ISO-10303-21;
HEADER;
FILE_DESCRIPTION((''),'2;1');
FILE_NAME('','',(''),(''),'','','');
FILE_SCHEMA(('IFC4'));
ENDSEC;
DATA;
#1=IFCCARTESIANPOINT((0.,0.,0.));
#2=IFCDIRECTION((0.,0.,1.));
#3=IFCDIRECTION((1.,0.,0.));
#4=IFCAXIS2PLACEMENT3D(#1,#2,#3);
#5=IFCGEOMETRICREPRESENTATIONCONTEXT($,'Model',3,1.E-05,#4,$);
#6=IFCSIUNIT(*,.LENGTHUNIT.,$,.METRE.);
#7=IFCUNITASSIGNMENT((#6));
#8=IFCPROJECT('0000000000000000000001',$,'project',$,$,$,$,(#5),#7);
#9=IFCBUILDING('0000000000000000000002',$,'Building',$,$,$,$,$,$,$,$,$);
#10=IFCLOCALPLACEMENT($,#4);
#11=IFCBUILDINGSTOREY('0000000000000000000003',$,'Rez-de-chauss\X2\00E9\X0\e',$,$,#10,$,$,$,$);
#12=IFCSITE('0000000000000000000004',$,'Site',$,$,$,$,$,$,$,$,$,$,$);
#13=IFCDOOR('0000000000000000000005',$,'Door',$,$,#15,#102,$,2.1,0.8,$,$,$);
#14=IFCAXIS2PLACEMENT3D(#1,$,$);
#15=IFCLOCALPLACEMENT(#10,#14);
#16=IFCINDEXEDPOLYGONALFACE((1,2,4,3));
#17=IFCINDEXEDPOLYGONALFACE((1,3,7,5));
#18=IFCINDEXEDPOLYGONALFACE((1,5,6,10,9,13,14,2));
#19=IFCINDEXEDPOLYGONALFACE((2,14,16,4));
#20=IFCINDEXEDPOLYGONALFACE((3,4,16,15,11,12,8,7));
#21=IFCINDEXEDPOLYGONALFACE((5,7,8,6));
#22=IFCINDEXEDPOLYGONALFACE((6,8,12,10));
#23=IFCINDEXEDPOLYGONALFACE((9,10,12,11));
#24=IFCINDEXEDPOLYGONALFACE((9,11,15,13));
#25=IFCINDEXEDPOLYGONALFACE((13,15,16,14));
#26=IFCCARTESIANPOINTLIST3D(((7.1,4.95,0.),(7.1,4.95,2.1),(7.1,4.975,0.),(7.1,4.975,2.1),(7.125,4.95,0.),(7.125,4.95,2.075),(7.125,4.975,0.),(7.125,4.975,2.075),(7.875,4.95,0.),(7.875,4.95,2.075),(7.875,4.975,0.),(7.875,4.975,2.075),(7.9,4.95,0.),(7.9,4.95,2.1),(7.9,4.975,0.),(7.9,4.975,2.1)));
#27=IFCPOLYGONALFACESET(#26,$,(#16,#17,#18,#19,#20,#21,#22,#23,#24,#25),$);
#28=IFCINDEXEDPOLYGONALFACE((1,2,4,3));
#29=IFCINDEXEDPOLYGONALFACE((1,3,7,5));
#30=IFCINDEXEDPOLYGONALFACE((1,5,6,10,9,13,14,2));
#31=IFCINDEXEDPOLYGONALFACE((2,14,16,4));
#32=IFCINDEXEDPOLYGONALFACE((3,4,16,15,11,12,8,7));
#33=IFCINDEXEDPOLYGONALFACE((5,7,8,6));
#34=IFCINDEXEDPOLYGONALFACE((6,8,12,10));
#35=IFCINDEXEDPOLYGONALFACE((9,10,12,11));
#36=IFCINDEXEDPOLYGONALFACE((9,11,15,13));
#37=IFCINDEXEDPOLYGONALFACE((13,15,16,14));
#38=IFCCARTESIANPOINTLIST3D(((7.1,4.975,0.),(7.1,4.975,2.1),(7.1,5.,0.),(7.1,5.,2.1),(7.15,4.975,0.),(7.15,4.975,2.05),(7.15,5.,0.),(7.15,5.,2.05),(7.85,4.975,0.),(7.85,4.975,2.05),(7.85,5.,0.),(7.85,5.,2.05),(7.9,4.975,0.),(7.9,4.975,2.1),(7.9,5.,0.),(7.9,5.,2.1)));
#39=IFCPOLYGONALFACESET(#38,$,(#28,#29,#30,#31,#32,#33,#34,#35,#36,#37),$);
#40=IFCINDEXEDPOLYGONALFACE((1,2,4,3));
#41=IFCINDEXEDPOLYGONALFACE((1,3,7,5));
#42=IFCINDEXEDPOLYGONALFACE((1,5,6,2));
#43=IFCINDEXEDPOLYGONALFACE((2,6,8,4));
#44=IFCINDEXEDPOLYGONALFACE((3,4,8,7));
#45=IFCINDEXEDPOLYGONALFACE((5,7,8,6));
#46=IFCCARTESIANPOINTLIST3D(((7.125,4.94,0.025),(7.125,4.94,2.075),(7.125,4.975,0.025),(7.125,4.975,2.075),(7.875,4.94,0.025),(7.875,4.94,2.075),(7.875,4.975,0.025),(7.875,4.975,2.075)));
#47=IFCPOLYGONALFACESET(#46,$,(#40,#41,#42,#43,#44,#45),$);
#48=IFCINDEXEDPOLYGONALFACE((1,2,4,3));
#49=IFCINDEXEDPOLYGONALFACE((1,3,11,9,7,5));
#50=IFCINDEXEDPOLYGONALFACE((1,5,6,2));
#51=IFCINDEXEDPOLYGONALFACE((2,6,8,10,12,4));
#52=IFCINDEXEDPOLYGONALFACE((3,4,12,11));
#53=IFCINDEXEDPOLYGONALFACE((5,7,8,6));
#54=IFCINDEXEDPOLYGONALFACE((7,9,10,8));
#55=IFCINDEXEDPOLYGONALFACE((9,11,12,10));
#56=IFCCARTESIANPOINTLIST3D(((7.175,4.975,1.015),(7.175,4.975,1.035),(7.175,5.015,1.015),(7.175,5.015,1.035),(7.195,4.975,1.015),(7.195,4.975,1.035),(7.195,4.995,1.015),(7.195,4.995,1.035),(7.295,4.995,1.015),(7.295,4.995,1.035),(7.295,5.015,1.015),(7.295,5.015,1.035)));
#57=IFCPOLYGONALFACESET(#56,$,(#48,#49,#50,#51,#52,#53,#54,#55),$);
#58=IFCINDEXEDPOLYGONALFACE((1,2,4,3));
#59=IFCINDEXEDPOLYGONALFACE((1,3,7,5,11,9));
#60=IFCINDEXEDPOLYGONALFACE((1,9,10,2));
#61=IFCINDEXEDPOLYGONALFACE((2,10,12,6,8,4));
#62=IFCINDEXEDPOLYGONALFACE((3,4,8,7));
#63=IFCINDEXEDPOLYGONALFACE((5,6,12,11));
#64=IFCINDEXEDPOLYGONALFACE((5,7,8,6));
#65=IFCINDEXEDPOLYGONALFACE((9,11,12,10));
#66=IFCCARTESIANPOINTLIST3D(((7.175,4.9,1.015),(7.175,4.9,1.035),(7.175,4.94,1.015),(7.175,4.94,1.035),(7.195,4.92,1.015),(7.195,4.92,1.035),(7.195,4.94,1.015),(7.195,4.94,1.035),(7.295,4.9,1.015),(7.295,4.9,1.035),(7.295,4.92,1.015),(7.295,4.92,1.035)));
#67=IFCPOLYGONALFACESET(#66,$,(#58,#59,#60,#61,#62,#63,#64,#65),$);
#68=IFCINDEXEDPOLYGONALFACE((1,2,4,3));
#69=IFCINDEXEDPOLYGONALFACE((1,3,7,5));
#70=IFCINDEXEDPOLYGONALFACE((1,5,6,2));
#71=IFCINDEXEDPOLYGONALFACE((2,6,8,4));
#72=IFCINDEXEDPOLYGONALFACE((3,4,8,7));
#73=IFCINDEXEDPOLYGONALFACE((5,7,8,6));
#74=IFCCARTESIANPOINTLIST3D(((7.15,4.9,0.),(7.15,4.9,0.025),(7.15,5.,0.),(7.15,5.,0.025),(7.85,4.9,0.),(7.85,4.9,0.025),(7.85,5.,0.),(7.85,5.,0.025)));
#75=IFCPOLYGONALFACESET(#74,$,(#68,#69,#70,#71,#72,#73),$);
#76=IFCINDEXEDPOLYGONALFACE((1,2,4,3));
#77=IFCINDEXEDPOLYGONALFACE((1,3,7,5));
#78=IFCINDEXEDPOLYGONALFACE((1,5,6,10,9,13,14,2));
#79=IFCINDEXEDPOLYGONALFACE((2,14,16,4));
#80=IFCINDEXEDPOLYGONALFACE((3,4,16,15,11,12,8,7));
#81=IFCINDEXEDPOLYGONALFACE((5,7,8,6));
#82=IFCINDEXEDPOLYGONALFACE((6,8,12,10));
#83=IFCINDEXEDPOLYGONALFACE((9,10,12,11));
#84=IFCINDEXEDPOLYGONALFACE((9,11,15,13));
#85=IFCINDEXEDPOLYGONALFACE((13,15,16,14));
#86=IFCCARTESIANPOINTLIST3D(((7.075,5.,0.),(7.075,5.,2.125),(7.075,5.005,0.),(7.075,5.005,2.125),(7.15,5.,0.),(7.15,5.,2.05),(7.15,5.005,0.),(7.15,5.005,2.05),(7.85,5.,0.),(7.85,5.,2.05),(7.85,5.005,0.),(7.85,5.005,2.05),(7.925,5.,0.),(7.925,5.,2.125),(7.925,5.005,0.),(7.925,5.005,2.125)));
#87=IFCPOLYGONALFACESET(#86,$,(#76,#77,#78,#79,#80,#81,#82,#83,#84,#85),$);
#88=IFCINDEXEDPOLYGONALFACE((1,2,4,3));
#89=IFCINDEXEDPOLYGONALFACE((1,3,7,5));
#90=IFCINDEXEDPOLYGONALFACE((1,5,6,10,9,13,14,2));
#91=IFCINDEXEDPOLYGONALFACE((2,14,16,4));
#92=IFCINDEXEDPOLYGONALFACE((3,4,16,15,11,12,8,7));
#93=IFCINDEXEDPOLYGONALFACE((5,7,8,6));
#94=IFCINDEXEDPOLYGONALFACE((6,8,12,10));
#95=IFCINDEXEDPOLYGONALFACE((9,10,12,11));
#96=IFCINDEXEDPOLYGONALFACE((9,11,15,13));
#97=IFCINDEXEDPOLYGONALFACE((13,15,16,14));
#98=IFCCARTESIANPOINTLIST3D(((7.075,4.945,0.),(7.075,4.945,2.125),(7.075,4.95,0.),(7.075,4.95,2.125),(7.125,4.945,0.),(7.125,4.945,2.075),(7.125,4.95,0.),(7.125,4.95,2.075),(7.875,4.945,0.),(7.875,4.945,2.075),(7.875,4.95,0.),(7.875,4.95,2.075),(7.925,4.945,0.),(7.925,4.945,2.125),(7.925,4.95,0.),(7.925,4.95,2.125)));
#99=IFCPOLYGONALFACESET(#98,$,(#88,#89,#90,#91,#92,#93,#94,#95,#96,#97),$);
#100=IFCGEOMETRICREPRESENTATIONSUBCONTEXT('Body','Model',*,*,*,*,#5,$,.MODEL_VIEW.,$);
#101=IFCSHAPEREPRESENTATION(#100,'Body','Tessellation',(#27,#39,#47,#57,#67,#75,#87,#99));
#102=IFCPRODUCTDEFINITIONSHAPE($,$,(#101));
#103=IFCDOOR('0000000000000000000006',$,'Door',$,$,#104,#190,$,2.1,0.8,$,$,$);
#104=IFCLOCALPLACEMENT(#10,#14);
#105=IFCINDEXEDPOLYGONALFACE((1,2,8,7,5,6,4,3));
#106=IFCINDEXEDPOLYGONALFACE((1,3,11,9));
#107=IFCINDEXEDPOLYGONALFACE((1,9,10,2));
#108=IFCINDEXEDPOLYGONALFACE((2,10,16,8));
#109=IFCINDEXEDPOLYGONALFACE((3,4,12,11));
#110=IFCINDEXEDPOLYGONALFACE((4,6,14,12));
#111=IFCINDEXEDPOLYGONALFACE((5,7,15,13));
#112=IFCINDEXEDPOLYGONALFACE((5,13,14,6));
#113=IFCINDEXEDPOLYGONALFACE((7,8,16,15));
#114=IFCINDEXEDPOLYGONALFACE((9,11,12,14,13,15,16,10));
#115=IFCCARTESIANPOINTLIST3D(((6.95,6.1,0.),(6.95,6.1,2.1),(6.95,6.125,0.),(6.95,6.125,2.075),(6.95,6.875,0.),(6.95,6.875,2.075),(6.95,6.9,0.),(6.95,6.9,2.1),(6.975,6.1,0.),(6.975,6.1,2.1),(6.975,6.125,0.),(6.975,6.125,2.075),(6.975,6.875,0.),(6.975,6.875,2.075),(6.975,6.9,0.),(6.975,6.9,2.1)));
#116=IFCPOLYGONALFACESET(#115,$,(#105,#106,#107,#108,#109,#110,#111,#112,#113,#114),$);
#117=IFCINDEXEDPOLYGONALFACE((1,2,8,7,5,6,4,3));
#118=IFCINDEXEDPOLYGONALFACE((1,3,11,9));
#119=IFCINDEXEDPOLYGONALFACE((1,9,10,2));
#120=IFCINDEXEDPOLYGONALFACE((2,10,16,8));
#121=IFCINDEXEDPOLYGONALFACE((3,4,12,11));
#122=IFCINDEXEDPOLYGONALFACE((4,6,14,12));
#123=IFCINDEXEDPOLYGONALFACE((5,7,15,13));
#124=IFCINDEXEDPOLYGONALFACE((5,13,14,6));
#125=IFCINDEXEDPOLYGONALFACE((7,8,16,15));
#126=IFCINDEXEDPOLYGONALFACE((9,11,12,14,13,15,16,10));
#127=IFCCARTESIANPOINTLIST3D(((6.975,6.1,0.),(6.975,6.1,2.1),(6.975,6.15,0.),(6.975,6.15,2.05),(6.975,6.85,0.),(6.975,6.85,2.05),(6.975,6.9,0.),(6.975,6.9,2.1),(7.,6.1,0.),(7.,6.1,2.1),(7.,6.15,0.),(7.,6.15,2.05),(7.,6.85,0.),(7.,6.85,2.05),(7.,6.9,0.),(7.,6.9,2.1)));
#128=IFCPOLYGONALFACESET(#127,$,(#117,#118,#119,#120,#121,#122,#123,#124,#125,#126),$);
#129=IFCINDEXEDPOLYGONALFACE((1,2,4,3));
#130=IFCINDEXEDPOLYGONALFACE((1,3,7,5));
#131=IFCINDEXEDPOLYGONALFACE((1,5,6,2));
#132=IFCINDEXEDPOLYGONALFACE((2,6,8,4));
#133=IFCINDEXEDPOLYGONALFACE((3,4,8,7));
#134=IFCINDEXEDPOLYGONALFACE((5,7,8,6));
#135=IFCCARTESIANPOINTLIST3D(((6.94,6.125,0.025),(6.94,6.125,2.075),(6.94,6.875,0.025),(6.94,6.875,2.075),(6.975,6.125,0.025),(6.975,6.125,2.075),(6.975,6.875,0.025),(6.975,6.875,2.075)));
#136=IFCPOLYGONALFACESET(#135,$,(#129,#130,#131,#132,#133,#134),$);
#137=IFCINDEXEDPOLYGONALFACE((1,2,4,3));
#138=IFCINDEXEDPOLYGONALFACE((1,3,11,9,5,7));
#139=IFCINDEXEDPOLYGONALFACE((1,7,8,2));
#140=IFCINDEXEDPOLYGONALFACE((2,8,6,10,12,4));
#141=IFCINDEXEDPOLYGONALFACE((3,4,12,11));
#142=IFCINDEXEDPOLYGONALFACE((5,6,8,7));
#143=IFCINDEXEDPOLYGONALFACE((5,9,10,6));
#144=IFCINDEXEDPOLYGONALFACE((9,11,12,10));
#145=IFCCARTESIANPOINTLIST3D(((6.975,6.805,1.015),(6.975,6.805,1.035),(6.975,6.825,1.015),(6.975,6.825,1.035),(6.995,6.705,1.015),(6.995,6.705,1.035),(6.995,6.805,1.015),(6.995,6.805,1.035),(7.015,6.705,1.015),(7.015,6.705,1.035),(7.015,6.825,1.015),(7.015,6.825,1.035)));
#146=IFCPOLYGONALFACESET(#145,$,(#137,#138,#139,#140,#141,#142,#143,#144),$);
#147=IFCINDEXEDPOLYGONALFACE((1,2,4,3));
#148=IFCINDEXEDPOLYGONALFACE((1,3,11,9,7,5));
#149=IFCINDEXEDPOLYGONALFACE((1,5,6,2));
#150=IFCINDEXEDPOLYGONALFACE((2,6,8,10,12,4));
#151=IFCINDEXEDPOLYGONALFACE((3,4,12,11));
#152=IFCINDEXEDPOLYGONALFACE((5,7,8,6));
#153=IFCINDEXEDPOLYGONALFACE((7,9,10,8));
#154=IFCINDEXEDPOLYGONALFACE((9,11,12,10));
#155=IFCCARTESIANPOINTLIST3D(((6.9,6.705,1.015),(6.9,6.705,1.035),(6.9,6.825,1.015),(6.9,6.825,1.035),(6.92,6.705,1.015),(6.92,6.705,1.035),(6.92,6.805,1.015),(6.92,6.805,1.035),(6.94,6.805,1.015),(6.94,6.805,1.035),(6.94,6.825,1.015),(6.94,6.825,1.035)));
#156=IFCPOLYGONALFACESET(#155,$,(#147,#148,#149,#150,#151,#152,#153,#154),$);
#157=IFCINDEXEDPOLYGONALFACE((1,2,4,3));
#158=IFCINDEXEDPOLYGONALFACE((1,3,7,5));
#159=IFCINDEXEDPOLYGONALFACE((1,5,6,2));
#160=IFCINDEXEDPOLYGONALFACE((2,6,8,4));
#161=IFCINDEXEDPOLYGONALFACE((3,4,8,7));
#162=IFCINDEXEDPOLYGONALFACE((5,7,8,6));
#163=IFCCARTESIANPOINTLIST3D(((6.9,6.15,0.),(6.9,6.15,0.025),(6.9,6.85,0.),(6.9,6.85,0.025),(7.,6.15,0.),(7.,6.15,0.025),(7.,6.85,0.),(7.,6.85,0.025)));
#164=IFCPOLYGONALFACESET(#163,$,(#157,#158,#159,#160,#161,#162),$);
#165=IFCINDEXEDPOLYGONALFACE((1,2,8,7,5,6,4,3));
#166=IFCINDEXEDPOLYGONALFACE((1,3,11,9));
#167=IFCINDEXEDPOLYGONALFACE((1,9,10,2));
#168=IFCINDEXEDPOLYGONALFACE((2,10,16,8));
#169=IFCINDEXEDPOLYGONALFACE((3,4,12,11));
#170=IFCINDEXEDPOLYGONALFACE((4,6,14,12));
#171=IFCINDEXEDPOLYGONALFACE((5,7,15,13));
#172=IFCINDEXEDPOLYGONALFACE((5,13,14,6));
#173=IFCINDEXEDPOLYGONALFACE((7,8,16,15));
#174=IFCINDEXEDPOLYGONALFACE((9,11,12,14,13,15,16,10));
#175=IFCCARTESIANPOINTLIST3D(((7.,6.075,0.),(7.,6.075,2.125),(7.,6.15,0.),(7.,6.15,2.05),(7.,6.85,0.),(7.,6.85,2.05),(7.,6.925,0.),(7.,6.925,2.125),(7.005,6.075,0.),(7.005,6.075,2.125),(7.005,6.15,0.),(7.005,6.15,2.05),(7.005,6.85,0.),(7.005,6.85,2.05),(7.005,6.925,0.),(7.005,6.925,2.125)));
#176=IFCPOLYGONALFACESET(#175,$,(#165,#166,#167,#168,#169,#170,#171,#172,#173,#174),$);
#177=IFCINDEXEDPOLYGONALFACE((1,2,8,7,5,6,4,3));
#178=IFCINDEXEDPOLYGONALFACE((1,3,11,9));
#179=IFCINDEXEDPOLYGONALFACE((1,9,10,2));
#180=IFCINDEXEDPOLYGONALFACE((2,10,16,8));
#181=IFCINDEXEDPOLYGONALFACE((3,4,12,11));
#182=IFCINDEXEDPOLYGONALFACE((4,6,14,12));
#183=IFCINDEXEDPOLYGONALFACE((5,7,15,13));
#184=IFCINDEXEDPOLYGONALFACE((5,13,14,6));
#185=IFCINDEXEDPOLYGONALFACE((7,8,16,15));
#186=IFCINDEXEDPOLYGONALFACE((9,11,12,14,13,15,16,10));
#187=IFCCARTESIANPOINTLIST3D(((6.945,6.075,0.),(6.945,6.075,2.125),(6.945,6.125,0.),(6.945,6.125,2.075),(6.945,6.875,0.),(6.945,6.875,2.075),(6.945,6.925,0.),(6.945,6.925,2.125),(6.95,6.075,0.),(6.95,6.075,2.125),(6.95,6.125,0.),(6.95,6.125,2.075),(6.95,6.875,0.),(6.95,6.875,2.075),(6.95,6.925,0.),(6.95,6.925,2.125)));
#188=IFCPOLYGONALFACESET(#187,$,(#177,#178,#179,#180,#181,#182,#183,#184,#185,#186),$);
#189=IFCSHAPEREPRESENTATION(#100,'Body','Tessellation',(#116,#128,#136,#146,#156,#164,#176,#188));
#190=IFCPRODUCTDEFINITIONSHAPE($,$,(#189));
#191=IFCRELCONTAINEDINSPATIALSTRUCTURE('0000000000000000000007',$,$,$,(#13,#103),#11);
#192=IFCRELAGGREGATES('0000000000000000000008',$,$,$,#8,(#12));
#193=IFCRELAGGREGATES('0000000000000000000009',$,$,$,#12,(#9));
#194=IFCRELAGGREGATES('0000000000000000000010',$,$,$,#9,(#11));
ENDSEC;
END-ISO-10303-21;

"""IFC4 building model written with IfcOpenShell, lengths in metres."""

from ifc_helpers import new_model, si_unit, frame, origin_with_axes, place, context, subcontext, project, spatial, line, indexed_curve, outline, extrude, element, save


model = new_model("IFC4")

# Units and contexts
model_context = context("Model", 3, precision=1e-05, world=origin_with_axes())
body_context = subcontext(model_context, "Body", "Model", "MODEL_VIEW")
ifc_project = project(units=[si_unit("LENGTHUNIT", "METRE")], contexts=[model_context])

# Site, building, storey
site = spatial("IfcSite", under=ifc_project, Name="Site")
building = spatial("IfcBuilding", under=site, Name="Building")
storey_placement = place(None, origin_with_axes())
storey = spatial("IfcBuildingStorey", under=building, at=storey_placement, Name="Rez-de-chaussée")

# Doors
door_1_placement = place(storey_placement, frame((7.9, 5.0, 0.0), z_axis=(0.0, 0.0, 1.0), x_axis=(-1.0, 0.0, 0.0)))
element("IfcDoor", 1, at=door_1_placement, inside=storey, Name="Door", OverallHeight=2.1, OverallWidth=0.8, context=body_context, shape_type="SweptSolid", body=[
    extrude(outline(indexed_curve([(0.0, 0.0), (0.0, 2.1), (0.8, 2.1), (0.8, 0.0), (0.775, 0.0), (0.775, 2.075), (0.025, 2.075), (0.025, 0.0)], segments=[line(1, 2, 3, 4, 5, 6, 7, 8, 1)])), frame((0.0, 0.025, 0.0), z_axis=(0.0, -1.0, 0.0), x_axis=(1.0, 0.0, 0.0)), (0.0, 0.0, -1.0), 0.025),
    extrude(outline(indexed_curve([(0.0, 0.0), (0.0, 2.1), (0.8, 2.1), (0.8, 0.0), (0.75, 0.0), (0.75, 2.05), (0.05, 2.05), (0.05, 0.0)], segments=[line(1, 2, 3, 4, 5, 6, 7, 8, 1)])), frame((0.0, 0.0, 0.0), z_axis=(0.0, -1.0, 0.0), x_axis=(1.0, 0.0, 0.0)), (0.0, 0.0, -1.0), 0.025),
    extrude(outline(indexed_curve([(0.0, 0.0), (0.75, 0.0), (0.75, 0.035), (0.0, 0.035)], segments=[line(1, 2, 3, 4, 1)])), frame((0.025, 0.025, 0.025), z_axis=(0.0, 0.0, 1.0), x_axis=(1.0, 0.0, 0.0)), (0.0, 0.0, 1.0), 2.05),
    extrude(outline(indexed_curve([(0.0, 0.0), (0.0, -0.04), (-0.12, -0.04), (-0.12, -0.02), (-0.02, -0.02), (-0.02, 0.0)], segments=[line(1, 2, 3, 4, 5, 6, 1)])), frame((0.725, 0.025, 1.015), z_axis=(0.0, 0.0, 1.0), x_axis=(1.0, 0.0, 0.0)), (0.0, 0.0, 1.0), 0.02),
    extrude(outline(indexed_curve([(0.0, 0.0), (0.0, 0.04), (-0.12, 0.04), (-0.12, 0.02), (-0.02, 0.02), (-0.02, 0.0)], segments=[line(1, 2, 3, 4, 5, 6, 1)])), frame((0.725, 0.06, 1.015), z_axis=(0.0, 0.0, 1.0), x_axis=(1.0, 0.0, 0.0)), (0.0, 0.0, 1.0), 0.02),
    extrude(outline(indexed_curve([(0.0, 0.0), (0.7, 0.0), (0.7, 0.1), (0.0, 0.1)], segments=[line(1, 2, 3, 4, 1)])), frame((0.05, 0.0, 0.0), z_axis=(0.0, 0.0, 1.0), x_axis=(1.0, 0.0, 0.0)), (0.0, 0.0, 1.0), 0.025),
    extrude(outline(indexed_curve([(0.0, 0.0), (0.0, 2.125), (0.85, 2.125), (0.85, 0.0), (0.775, 0.0), (0.775, 2.05), (0.075, 2.05), (0.075, 0.0)], segments=[line(1, 2, 3, 4, 5, 6, 7, 8, 1)])), frame((-0.025, -0.005, 0.0), z_axis=(0.0, -1.0, 0.0), x_axis=(1.0, 0.0, 0.0)), (0.0, 0.0, -1.0), 0.005),
    extrude(outline(indexed_curve([(0.0, 0.0), (0.0, 2.125), (0.85, 2.125), (0.85, 0.0), (0.8, 0.0), (0.8, 2.075), (0.05, 2.075), (0.05, 0.0)], segments=[line(1, 2, 3, 4, 5, 6, 7, 8, 1)])), frame((-0.025, 0.05, 0.0), z_axis=(0.0, -1.0, 0.0), x_axis=(1.0, 0.0, 0.0)), (0.0, 0.0, -1.0), 0.005),
])
door_2_placement = place(storey_placement, frame((7.0, 6.1, 0.0), z_axis=(0.0, 0.0, 1.0), x_axis=(0.0, 1.0, 0.0)))
element("IfcDoor", 2, at=door_2_placement, inside=storey, Name="Door", OverallHeight=2.1, OverallWidth=0.8, context=body_context, shape_type="SweptSolid", body=[
    extrude(outline(indexed_curve([(0.0, 0.0), (0.0, 2.1), (0.8, 2.1), (0.8, 0.0), (0.775, 0.0), (0.775, 2.075), (0.025, 2.075), (0.025, 0.0)], segments=[line(1, 2, 3, 4, 5, 6, 7, 8, 1)])), frame((0.0, 0.025, 0.0), z_axis=(0.0, -1.0, 0.0), x_axis=(1.0, 0.0, 0.0)), (0.0, 0.0, -1.0), 0.025),
    extrude(outline(indexed_curve([(0.0, 0.0), (0.0, 2.1), (0.8, 2.1), (0.8, 0.0), (0.75, 0.0), (0.75, 2.05), (0.05, 2.05), (0.05, 0.0)], segments=[line(1, 2, 3, 4, 5, 6, 7, 8, 1)])), frame((0.0, 0.0, 0.0), z_axis=(0.0, -1.0, 0.0), x_axis=(1.0, 0.0, 0.0)), (0.0, 0.0, -1.0), 0.025),
    extrude(outline(indexed_curve([(0.0, 0.0), (0.75, 0.0), (0.75, 0.035), (0.0, 0.035)], segments=[line(1, 2, 3, 4, 1)])), frame((0.025, 0.025, 0.025), z_axis=(0.0, 0.0, 1.0), x_axis=(1.0, 0.0, 0.0)), (0.0, 0.0, 1.0), 2.05),
    extrude(outline(indexed_curve([(0.0, 0.0), (0.0, -0.04), (-0.12, -0.04), (-0.12, -0.02), (-0.02, -0.02), (-0.02, 0.0)], segments=[line(1, 2, 3, 4, 5, 6, 1)])), frame((0.725, 0.025, 1.015), z_axis=(0.0, 0.0, 1.0), x_axis=(1.0, 0.0, 0.0)), (0.0, 0.0, 1.0), 0.02),
    extrude(outline(indexed_curve([(0.0, 0.0), (0.0, 0.04), (-0.12, 0.04), (-0.12, 0.02), (-0.02, 0.02), (-0.02, 0.0)], segments=[line(1, 2, 3, 4, 5, 6, 1)])), frame((0.725, 0.06, 1.015), z_axis=(0.0, 0.0, 1.0), x_axis=(1.0, 0.0, 0.0)), (0.0, 0.0, 1.0), 0.02),
    extrude(outline(indexed_curve([(0.0, 0.0), (0.7, 0.0), (0.7, 0.1), (0.0, 0.1)], segments=[line(1, 2, 3, 4, 1)])), frame((0.05, 0.0, 0.0), z_axis=(0.0, 0.0, 1.0), x_axis=(1.0, 0.0, 0.0)), (0.0, 0.0, 1.0), 0.025),
    extrude(outline(indexed_curve([(0.0, 0.0), (0.0, 2.125), (0.85, 2.125), (0.85, 0.0), (0.775, 0.0), (0.775, 2.05), (0.075, 2.05), (0.075, 0.0)], segments=[line(1, 2, 3, 4, 5, 6, 7, 8, 1)])), frame((-0.025, -0.005, 0.0), z_axis=(0.0, -1.0, 0.0), x_axis=(1.0, 0.0, 0.0)), (0.0, 0.0, -1.0), 0.005),
    extrude(outline(indexed_curve([(0.0, 0.0), (0.0, 2.125), (0.85, 2.125), (0.85, 0.0), (0.8, 0.0), (0.8, 2.075), (0.05, 2.075), (0.05, 0.0)], segments=[line(1, 2, 3, 4, 5, 6, 7, 8, 1)])), frame((-0.025, 0.05, 0.0), z_axis=(0.0, -1.0, 0.0), x_axis=(1.0, 0.0, 0.0)), (0.0, 0.0, -1.0), 0.005),
])

save(model, "model.ifc")
